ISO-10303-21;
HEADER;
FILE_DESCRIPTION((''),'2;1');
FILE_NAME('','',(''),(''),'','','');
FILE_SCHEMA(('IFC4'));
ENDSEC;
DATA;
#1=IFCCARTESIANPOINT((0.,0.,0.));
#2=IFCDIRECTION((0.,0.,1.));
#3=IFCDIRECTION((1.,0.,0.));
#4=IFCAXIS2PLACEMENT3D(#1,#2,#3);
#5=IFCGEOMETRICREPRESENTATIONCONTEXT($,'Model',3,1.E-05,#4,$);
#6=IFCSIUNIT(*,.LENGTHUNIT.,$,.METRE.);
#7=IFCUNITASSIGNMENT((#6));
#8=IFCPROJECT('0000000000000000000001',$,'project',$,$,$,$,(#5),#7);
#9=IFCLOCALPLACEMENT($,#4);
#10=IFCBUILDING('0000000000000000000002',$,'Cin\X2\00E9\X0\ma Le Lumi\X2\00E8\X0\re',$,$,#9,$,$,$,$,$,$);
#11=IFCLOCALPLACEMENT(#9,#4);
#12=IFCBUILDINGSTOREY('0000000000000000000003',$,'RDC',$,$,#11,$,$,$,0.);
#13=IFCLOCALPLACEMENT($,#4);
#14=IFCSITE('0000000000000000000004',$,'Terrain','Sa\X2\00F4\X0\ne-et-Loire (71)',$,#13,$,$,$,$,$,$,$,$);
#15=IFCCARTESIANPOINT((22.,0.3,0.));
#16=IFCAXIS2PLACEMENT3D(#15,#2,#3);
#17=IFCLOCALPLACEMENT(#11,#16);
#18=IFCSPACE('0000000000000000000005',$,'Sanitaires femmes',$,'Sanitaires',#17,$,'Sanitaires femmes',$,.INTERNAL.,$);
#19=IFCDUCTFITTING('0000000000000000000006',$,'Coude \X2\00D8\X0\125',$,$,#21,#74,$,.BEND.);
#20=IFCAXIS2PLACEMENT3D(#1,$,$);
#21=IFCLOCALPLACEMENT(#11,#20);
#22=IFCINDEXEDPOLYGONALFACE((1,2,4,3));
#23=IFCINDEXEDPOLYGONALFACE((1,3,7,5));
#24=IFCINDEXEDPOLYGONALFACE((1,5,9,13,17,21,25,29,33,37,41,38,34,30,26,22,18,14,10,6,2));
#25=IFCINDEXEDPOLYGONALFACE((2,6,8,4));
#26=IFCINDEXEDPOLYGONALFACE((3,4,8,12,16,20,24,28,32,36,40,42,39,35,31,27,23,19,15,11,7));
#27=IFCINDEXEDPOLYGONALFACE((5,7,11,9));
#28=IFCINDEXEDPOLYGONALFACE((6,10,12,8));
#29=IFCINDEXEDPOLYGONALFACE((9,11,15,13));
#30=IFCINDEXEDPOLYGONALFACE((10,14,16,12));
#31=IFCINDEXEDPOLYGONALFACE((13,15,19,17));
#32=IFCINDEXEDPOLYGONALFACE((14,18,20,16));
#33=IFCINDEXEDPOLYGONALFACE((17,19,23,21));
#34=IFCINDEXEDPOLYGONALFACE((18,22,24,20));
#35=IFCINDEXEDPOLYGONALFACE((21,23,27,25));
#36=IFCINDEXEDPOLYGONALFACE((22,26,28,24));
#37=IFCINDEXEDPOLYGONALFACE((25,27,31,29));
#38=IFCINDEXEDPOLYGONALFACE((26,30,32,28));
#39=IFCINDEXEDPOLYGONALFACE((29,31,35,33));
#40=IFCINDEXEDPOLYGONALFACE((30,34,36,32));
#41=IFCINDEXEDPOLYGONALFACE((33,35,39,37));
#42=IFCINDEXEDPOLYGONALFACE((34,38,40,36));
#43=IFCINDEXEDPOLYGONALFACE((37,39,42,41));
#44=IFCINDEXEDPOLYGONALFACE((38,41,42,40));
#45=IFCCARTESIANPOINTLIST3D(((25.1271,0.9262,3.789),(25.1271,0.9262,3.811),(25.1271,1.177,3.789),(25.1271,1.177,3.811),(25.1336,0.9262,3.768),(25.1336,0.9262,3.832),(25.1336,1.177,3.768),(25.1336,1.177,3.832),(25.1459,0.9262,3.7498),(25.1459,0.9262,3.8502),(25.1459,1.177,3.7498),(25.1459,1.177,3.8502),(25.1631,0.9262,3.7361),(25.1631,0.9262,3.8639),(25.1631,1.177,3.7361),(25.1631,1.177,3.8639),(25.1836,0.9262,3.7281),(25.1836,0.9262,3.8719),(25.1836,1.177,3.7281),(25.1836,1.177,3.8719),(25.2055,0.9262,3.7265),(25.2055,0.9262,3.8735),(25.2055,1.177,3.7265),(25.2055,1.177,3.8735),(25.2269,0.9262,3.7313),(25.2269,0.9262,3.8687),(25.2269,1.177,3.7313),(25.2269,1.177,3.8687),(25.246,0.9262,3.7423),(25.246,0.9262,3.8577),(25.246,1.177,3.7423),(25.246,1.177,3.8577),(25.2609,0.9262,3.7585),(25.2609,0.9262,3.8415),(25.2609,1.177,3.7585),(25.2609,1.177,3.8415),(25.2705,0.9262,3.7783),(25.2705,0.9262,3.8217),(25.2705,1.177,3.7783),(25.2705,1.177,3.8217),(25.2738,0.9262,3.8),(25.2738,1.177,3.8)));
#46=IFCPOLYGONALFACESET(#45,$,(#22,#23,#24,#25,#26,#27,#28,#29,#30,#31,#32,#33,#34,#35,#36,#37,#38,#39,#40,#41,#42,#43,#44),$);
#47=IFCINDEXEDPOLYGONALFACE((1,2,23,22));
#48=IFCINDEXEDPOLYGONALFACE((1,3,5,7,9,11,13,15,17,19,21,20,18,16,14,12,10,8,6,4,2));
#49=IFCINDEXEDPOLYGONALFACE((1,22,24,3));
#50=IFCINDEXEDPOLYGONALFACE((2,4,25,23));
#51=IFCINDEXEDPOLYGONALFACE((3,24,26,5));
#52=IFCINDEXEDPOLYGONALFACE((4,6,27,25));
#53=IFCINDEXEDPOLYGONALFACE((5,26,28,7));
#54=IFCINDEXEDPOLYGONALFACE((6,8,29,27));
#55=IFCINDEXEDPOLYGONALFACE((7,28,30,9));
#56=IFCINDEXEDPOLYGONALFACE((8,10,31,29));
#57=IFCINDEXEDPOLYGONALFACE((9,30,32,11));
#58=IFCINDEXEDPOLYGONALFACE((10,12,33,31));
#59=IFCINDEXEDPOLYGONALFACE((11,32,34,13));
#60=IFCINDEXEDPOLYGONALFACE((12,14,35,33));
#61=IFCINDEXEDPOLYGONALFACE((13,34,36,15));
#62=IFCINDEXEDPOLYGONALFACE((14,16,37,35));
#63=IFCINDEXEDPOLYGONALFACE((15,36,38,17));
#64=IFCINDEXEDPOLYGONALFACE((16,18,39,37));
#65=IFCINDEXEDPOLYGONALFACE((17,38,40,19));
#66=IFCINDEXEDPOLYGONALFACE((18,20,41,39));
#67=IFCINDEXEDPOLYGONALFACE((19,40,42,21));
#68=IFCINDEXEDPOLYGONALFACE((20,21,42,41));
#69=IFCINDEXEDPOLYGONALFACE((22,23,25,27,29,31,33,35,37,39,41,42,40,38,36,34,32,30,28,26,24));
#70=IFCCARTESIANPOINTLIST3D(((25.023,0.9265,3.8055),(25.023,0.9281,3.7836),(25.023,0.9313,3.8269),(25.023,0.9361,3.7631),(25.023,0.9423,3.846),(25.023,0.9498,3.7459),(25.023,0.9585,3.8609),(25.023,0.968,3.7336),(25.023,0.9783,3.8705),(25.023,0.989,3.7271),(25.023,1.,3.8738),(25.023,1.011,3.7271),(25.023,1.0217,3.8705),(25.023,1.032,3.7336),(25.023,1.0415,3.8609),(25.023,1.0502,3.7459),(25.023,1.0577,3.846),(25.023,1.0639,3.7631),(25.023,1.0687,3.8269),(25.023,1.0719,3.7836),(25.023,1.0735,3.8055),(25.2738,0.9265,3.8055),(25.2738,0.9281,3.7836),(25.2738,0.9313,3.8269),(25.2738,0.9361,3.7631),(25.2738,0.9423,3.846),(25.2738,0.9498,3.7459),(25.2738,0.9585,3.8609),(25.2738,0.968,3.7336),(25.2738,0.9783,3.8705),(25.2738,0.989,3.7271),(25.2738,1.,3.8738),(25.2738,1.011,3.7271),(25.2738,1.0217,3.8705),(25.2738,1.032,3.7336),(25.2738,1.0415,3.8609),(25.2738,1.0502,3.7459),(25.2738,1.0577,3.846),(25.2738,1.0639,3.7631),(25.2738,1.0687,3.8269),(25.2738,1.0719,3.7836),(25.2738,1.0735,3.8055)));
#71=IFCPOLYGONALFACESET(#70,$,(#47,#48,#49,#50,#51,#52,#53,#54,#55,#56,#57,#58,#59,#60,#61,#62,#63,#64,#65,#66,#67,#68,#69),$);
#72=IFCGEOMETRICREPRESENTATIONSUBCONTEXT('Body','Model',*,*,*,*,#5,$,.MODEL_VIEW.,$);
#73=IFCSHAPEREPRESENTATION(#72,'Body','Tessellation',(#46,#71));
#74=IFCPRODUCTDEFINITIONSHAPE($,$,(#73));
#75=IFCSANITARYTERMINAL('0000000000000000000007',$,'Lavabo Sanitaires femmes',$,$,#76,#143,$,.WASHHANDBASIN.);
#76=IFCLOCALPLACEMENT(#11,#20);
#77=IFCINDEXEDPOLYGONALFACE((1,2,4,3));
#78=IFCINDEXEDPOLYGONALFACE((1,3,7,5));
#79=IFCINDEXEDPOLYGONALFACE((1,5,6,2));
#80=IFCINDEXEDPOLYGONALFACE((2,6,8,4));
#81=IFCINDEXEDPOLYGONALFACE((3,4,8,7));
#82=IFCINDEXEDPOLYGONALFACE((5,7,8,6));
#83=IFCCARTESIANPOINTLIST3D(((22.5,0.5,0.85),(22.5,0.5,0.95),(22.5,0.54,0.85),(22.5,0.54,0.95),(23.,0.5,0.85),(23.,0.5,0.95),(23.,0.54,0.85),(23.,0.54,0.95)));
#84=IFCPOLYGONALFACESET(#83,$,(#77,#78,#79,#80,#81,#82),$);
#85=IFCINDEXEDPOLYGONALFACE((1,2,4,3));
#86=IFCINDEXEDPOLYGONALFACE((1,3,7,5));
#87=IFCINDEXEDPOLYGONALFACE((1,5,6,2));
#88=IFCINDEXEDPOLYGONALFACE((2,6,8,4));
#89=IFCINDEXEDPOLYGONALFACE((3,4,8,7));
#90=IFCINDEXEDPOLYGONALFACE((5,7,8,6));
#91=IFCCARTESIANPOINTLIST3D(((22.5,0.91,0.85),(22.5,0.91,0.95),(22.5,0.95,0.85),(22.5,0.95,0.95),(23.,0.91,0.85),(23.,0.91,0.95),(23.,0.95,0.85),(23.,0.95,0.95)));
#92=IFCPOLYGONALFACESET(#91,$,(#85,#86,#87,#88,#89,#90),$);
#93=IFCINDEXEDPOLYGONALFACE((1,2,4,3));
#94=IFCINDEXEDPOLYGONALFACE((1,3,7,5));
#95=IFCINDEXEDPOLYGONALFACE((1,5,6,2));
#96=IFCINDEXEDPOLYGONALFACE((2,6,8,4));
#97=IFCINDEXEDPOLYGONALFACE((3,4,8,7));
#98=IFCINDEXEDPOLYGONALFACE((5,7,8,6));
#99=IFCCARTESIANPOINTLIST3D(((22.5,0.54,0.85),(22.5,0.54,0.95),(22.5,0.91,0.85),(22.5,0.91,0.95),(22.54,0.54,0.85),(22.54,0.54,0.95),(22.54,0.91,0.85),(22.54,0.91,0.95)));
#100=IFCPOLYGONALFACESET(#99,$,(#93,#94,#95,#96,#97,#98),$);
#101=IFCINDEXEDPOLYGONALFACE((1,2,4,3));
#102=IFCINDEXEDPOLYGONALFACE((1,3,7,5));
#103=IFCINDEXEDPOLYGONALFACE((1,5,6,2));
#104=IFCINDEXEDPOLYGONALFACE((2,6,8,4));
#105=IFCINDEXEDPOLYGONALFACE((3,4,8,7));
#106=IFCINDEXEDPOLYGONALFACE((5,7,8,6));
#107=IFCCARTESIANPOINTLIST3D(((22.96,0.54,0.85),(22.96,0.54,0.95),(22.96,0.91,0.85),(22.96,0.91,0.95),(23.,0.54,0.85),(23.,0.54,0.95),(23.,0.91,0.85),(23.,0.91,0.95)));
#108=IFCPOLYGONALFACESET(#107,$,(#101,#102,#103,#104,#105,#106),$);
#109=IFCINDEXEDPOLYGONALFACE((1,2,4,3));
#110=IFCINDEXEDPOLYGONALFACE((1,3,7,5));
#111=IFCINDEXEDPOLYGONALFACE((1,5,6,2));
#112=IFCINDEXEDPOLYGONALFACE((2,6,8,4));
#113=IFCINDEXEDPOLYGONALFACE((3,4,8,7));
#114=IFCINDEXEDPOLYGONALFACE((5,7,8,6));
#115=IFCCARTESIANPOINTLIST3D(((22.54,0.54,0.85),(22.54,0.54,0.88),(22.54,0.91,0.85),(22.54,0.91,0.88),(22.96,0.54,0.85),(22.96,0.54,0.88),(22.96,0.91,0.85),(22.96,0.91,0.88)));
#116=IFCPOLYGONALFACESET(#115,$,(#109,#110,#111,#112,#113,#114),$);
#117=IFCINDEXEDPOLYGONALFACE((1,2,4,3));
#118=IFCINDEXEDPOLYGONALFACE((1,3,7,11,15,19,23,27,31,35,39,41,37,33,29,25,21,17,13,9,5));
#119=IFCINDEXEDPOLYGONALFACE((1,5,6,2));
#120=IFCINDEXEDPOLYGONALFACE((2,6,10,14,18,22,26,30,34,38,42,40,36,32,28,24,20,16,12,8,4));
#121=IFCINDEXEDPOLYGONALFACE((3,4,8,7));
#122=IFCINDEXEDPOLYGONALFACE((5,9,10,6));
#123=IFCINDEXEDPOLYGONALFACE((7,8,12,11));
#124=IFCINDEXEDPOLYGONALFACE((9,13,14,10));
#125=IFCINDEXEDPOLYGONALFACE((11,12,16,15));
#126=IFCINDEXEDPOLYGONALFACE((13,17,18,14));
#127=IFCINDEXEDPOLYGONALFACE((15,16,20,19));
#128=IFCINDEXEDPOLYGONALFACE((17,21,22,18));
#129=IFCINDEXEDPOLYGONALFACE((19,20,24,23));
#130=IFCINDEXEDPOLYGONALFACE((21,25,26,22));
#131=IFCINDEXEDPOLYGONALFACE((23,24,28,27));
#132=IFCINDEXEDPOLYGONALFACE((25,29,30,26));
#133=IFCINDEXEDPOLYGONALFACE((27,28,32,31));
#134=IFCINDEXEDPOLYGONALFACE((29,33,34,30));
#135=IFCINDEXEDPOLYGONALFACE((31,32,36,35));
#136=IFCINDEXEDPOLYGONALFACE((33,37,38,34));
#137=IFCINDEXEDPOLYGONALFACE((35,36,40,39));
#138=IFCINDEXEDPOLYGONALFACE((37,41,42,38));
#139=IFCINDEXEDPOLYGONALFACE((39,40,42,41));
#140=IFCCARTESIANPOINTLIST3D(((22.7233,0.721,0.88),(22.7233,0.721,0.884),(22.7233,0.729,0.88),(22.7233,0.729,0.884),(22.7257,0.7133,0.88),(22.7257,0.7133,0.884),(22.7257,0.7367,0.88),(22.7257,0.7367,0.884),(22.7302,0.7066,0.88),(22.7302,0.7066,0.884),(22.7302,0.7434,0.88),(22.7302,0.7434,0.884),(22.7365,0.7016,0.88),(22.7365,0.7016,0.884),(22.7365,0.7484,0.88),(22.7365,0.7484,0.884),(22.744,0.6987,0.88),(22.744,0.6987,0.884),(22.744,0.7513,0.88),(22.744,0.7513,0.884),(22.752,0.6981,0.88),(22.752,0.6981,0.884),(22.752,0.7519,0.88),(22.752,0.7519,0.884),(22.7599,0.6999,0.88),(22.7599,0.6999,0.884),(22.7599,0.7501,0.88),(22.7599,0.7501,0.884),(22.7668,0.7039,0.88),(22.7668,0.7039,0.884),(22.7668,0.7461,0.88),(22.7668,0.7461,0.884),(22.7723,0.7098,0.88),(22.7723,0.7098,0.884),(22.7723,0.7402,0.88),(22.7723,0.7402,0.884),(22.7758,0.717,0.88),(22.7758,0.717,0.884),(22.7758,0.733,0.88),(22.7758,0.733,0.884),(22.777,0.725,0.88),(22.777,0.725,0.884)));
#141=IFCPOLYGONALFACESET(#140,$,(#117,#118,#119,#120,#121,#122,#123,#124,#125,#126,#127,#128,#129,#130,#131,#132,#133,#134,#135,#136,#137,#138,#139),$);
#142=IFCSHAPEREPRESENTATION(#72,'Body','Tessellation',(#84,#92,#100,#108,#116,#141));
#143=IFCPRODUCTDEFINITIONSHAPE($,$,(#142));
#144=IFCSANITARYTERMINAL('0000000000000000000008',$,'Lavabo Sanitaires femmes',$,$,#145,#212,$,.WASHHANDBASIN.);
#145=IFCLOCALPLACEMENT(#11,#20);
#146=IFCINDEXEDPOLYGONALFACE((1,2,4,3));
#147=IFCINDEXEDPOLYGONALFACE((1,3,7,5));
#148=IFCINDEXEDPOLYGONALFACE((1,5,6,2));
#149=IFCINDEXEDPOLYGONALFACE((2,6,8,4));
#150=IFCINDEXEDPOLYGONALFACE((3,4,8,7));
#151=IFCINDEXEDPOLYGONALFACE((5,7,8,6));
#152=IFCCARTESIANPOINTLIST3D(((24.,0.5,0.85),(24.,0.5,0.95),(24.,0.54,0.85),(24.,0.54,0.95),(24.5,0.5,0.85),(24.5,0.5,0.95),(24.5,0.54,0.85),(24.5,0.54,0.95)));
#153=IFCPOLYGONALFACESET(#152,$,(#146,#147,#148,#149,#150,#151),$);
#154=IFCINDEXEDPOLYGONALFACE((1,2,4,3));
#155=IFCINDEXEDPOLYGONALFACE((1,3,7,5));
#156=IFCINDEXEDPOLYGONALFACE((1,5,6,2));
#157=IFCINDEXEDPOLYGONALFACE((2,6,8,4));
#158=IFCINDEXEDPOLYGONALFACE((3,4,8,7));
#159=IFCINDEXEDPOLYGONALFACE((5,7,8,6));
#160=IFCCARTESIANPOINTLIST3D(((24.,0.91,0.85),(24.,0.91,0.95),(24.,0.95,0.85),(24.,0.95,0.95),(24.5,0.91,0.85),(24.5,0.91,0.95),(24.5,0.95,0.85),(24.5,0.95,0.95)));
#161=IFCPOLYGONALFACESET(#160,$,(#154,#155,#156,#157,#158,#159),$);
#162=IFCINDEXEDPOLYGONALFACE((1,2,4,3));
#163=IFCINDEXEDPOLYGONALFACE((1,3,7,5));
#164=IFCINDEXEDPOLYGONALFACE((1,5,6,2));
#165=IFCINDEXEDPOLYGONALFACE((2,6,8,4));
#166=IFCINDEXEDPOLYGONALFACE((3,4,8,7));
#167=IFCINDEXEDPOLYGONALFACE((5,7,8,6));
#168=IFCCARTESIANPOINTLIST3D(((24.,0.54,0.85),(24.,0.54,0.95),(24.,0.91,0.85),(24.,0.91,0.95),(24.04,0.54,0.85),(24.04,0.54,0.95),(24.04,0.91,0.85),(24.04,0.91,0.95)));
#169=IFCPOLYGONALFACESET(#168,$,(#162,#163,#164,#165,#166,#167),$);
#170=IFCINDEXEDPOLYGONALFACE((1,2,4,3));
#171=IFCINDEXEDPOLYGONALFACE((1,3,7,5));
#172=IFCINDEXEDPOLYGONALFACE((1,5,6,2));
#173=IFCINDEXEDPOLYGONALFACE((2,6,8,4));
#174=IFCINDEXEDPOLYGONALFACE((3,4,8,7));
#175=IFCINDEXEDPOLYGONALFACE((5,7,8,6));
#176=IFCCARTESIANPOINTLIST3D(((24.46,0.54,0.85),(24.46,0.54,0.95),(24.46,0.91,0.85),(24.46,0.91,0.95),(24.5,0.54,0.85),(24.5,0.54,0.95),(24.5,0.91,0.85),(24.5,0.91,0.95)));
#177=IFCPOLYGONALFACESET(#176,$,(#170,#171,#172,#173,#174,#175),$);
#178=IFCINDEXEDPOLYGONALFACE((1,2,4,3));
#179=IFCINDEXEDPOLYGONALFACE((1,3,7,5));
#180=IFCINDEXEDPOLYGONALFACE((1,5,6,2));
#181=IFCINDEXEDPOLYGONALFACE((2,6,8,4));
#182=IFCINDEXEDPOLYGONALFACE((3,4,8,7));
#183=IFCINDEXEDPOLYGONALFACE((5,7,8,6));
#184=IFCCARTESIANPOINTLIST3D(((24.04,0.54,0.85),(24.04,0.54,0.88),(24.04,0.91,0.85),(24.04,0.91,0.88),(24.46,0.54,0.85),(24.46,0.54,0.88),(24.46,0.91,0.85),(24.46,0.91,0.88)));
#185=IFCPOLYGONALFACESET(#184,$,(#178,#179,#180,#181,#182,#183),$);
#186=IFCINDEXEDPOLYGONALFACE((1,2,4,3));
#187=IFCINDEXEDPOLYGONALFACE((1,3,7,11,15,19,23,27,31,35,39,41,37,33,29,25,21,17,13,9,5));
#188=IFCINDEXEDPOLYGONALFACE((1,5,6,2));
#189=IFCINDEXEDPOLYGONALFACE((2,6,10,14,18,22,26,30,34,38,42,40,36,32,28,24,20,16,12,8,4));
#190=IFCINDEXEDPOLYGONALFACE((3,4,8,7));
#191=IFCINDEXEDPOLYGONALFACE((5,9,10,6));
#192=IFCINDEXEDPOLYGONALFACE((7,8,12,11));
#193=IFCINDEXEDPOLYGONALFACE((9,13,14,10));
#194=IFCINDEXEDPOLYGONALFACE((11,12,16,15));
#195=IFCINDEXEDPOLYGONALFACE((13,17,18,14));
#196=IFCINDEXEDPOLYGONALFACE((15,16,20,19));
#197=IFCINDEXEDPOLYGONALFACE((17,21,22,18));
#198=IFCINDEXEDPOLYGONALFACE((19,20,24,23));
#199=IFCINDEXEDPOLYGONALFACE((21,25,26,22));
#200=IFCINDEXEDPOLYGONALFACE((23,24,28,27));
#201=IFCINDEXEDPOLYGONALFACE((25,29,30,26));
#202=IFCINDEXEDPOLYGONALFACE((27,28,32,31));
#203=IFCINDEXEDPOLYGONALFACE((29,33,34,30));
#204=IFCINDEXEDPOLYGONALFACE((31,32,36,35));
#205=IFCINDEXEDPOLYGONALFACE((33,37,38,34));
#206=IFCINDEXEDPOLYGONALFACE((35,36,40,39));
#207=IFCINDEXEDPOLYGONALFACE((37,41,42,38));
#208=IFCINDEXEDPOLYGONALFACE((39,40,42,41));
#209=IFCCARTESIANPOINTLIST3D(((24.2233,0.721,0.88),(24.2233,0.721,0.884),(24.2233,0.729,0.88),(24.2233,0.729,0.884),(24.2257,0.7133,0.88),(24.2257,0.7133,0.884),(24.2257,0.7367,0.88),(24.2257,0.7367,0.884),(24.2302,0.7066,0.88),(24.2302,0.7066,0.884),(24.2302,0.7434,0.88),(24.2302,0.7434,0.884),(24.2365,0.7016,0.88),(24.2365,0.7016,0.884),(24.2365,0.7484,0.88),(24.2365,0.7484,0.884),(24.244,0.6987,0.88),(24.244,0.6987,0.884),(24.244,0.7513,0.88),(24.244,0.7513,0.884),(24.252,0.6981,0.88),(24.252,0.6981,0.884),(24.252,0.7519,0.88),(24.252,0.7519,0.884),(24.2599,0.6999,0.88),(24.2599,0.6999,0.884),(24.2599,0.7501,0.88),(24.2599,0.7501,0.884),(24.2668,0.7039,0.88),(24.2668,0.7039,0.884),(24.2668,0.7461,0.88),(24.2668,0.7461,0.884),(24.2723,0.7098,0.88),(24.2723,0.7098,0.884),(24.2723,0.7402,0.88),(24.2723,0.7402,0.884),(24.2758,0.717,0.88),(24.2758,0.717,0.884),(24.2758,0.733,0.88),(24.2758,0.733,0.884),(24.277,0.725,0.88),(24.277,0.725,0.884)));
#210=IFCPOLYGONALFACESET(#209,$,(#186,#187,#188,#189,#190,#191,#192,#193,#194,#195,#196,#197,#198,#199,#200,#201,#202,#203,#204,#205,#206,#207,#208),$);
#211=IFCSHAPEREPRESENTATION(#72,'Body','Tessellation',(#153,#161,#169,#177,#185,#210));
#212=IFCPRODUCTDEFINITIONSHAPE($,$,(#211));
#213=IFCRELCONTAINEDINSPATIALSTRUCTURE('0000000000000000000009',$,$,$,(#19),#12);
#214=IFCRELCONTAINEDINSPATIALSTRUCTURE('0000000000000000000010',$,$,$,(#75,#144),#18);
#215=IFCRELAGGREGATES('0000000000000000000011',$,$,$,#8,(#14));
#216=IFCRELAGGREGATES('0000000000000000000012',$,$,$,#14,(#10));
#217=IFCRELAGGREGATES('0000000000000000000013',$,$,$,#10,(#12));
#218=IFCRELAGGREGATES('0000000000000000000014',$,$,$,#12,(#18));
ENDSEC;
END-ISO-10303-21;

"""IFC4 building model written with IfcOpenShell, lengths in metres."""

from ifc_helpers import new_model, si_unit, frame, frame_2d, origin_with_axes, place, context, subcontext, project, spatial, rectangle, circle, extrude, element, save


model = new_model("IFC4")

# Units and contexts
model_context = context("Model", 3, precision=1e-05, world=origin_with_axes())
body_context = subcontext(model_context, "Body", "Model", "MODEL_VIEW")
ifc_project = project(units=[si_unit("LENGTHUNIT", "METRE")], contexts=[model_context])

# Site, building, storey
site_placement = place(None, origin_with_axes())
site = spatial("IfcSite", under=ifc_project, at=site_placement, Name="Terrain", Description="Saône-et-Loire (71)")
building_placement = place(None, origin_with_axes())
building = spatial("IfcBuilding", under=site, at=building_placement, Name="Cinéma Le Lumière")
storey_placement = place(building_placement, origin_with_axes())
storey = spatial("IfcBuildingStorey", under=building, at=storey_placement, Name="RDC", Elevation=0.0)

# Duct fitting
for number, where, z_axis, x_axis, name in (
    (1, (25.2, 1.0, 3.8), (0.0, 0.0, 1.0), (1.0, 0.0, 0.0), "Coude Ø125"),
):
    element("IfcDuctFitting", number, at=place(storey_placement, frame(where, z_axis=z_axis, x_axis=x_axis)), inside=storey, Name=name, PredefinedType="BEND", context=body_context, shape_type="SweptSolid", body=[
        extrude(circle(Radius=0.0737), frame((0.0, -0.0737, 0.0), z_axis=(0.0, 1.0, 0.0), x_axis=(1.0, 0.0, 0.0)), (0.0, 0.0, 1.0), 0.2507),
        extrude(circle(Radius=0.0737), frame((0.0737, 0.0, 0.0), z_axis=(-1.0, 0.0, 0.0), x_axis=(0.0, 0.0, 1.0)), (0.0, 0.0, 1.0), 0.2507),
    ])

# Shared definitions
space_1_placement = place(storey_placement, frame((22.0, 0.3, 0.0), z_axis=(0.0, 0.0, 1.0), x_axis=(1.0, 0.0, 0.0)))
space_1 = spatial("IfcSpace", under=storey, at=space_1_placement, Name="Sanitaires femmes", ObjectType="Sanitaires", LongName="Sanitaires femmes", PredefinedType="INTERNAL")

# Sanitary terminals
for number, where, z_axis, x_axis, name in (
    (2, (0.5, 0.2, 0.85), (0.0, 0.0, 1.0), (1.0, 0.0, 0.0), "Lavabo Sanitaires femmes"),
    (3, (2.0, 0.2, 0.85), (0.0, 0.0, 1.0), (1.0, 0.0, 0.0), "Lavabo Sanitaires femmes"),
):
    element("IfcSanitaryTerminal", number, at=place(space_1_placement, frame(where, z_axis=z_axis, x_axis=x_axis)), inside=space_1, Name=name, PredefinedType="WASHHANDBASIN", context=body_context, shape_type="SweptSolid", body=[
        extrude(rectangle(XDim=0.5, YDim=0.04, at=frame_2d((0.25, 0.02))), origin_with_axes(), (0.0, 0.0, 1.0), 0.1),
        extrude(rectangle(XDim=0.5, YDim=0.04, at=frame_2d((0.25, 0.02))), frame((0.0, 0.41, 0.0), z_axis=(0.0, 0.0, 1.0), x_axis=(1.0, 0.0, 0.0)), (0.0, 0.0, 1.0), 0.1),
        extrude(rectangle(XDim=0.04, YDim=0.37, at=frame_2d((0.02, 0.185))), frame((0.0, 0.04, 0.0), z_axis=(0.0, 0.0, 1.0), x_axis=(1.0, 0.0, 0.0)), (0.0, 0.0, 1.0), 0.1),
        extrude(rectangle(XDim=0.04, YDim=0.37, at=frame_2d((0.02, 0.185))), frame((0.46, 0.04, 0.0), z_axis=(0.0, 0.0, 1.0), x_axis=(1.0, 0.0, 0.0)), (0.0, 0.0, 1.0), 0.1),
        extrude(rectangle(XDim=0.42, YDim=0.37, at=frame_2d((0.21, 0.185))), frame((0.04, 0.04, 0.0), z_axis=(0.0, 0.0, 1.0), x_axis=(1.0, 0.0, 0.0)), (0.0, 0.0, 1.0), 0.03),
        extrude(circle(Radius=0.027), frame((0.25, 0.225, 0.03), z_axis=(0.0, 0.0, 1.0), x_axis=(1.0, 0.0, 0.0)), (0.0, 0.0, 1.0), 0.004),
    ])

save(model, "model.ifc")
